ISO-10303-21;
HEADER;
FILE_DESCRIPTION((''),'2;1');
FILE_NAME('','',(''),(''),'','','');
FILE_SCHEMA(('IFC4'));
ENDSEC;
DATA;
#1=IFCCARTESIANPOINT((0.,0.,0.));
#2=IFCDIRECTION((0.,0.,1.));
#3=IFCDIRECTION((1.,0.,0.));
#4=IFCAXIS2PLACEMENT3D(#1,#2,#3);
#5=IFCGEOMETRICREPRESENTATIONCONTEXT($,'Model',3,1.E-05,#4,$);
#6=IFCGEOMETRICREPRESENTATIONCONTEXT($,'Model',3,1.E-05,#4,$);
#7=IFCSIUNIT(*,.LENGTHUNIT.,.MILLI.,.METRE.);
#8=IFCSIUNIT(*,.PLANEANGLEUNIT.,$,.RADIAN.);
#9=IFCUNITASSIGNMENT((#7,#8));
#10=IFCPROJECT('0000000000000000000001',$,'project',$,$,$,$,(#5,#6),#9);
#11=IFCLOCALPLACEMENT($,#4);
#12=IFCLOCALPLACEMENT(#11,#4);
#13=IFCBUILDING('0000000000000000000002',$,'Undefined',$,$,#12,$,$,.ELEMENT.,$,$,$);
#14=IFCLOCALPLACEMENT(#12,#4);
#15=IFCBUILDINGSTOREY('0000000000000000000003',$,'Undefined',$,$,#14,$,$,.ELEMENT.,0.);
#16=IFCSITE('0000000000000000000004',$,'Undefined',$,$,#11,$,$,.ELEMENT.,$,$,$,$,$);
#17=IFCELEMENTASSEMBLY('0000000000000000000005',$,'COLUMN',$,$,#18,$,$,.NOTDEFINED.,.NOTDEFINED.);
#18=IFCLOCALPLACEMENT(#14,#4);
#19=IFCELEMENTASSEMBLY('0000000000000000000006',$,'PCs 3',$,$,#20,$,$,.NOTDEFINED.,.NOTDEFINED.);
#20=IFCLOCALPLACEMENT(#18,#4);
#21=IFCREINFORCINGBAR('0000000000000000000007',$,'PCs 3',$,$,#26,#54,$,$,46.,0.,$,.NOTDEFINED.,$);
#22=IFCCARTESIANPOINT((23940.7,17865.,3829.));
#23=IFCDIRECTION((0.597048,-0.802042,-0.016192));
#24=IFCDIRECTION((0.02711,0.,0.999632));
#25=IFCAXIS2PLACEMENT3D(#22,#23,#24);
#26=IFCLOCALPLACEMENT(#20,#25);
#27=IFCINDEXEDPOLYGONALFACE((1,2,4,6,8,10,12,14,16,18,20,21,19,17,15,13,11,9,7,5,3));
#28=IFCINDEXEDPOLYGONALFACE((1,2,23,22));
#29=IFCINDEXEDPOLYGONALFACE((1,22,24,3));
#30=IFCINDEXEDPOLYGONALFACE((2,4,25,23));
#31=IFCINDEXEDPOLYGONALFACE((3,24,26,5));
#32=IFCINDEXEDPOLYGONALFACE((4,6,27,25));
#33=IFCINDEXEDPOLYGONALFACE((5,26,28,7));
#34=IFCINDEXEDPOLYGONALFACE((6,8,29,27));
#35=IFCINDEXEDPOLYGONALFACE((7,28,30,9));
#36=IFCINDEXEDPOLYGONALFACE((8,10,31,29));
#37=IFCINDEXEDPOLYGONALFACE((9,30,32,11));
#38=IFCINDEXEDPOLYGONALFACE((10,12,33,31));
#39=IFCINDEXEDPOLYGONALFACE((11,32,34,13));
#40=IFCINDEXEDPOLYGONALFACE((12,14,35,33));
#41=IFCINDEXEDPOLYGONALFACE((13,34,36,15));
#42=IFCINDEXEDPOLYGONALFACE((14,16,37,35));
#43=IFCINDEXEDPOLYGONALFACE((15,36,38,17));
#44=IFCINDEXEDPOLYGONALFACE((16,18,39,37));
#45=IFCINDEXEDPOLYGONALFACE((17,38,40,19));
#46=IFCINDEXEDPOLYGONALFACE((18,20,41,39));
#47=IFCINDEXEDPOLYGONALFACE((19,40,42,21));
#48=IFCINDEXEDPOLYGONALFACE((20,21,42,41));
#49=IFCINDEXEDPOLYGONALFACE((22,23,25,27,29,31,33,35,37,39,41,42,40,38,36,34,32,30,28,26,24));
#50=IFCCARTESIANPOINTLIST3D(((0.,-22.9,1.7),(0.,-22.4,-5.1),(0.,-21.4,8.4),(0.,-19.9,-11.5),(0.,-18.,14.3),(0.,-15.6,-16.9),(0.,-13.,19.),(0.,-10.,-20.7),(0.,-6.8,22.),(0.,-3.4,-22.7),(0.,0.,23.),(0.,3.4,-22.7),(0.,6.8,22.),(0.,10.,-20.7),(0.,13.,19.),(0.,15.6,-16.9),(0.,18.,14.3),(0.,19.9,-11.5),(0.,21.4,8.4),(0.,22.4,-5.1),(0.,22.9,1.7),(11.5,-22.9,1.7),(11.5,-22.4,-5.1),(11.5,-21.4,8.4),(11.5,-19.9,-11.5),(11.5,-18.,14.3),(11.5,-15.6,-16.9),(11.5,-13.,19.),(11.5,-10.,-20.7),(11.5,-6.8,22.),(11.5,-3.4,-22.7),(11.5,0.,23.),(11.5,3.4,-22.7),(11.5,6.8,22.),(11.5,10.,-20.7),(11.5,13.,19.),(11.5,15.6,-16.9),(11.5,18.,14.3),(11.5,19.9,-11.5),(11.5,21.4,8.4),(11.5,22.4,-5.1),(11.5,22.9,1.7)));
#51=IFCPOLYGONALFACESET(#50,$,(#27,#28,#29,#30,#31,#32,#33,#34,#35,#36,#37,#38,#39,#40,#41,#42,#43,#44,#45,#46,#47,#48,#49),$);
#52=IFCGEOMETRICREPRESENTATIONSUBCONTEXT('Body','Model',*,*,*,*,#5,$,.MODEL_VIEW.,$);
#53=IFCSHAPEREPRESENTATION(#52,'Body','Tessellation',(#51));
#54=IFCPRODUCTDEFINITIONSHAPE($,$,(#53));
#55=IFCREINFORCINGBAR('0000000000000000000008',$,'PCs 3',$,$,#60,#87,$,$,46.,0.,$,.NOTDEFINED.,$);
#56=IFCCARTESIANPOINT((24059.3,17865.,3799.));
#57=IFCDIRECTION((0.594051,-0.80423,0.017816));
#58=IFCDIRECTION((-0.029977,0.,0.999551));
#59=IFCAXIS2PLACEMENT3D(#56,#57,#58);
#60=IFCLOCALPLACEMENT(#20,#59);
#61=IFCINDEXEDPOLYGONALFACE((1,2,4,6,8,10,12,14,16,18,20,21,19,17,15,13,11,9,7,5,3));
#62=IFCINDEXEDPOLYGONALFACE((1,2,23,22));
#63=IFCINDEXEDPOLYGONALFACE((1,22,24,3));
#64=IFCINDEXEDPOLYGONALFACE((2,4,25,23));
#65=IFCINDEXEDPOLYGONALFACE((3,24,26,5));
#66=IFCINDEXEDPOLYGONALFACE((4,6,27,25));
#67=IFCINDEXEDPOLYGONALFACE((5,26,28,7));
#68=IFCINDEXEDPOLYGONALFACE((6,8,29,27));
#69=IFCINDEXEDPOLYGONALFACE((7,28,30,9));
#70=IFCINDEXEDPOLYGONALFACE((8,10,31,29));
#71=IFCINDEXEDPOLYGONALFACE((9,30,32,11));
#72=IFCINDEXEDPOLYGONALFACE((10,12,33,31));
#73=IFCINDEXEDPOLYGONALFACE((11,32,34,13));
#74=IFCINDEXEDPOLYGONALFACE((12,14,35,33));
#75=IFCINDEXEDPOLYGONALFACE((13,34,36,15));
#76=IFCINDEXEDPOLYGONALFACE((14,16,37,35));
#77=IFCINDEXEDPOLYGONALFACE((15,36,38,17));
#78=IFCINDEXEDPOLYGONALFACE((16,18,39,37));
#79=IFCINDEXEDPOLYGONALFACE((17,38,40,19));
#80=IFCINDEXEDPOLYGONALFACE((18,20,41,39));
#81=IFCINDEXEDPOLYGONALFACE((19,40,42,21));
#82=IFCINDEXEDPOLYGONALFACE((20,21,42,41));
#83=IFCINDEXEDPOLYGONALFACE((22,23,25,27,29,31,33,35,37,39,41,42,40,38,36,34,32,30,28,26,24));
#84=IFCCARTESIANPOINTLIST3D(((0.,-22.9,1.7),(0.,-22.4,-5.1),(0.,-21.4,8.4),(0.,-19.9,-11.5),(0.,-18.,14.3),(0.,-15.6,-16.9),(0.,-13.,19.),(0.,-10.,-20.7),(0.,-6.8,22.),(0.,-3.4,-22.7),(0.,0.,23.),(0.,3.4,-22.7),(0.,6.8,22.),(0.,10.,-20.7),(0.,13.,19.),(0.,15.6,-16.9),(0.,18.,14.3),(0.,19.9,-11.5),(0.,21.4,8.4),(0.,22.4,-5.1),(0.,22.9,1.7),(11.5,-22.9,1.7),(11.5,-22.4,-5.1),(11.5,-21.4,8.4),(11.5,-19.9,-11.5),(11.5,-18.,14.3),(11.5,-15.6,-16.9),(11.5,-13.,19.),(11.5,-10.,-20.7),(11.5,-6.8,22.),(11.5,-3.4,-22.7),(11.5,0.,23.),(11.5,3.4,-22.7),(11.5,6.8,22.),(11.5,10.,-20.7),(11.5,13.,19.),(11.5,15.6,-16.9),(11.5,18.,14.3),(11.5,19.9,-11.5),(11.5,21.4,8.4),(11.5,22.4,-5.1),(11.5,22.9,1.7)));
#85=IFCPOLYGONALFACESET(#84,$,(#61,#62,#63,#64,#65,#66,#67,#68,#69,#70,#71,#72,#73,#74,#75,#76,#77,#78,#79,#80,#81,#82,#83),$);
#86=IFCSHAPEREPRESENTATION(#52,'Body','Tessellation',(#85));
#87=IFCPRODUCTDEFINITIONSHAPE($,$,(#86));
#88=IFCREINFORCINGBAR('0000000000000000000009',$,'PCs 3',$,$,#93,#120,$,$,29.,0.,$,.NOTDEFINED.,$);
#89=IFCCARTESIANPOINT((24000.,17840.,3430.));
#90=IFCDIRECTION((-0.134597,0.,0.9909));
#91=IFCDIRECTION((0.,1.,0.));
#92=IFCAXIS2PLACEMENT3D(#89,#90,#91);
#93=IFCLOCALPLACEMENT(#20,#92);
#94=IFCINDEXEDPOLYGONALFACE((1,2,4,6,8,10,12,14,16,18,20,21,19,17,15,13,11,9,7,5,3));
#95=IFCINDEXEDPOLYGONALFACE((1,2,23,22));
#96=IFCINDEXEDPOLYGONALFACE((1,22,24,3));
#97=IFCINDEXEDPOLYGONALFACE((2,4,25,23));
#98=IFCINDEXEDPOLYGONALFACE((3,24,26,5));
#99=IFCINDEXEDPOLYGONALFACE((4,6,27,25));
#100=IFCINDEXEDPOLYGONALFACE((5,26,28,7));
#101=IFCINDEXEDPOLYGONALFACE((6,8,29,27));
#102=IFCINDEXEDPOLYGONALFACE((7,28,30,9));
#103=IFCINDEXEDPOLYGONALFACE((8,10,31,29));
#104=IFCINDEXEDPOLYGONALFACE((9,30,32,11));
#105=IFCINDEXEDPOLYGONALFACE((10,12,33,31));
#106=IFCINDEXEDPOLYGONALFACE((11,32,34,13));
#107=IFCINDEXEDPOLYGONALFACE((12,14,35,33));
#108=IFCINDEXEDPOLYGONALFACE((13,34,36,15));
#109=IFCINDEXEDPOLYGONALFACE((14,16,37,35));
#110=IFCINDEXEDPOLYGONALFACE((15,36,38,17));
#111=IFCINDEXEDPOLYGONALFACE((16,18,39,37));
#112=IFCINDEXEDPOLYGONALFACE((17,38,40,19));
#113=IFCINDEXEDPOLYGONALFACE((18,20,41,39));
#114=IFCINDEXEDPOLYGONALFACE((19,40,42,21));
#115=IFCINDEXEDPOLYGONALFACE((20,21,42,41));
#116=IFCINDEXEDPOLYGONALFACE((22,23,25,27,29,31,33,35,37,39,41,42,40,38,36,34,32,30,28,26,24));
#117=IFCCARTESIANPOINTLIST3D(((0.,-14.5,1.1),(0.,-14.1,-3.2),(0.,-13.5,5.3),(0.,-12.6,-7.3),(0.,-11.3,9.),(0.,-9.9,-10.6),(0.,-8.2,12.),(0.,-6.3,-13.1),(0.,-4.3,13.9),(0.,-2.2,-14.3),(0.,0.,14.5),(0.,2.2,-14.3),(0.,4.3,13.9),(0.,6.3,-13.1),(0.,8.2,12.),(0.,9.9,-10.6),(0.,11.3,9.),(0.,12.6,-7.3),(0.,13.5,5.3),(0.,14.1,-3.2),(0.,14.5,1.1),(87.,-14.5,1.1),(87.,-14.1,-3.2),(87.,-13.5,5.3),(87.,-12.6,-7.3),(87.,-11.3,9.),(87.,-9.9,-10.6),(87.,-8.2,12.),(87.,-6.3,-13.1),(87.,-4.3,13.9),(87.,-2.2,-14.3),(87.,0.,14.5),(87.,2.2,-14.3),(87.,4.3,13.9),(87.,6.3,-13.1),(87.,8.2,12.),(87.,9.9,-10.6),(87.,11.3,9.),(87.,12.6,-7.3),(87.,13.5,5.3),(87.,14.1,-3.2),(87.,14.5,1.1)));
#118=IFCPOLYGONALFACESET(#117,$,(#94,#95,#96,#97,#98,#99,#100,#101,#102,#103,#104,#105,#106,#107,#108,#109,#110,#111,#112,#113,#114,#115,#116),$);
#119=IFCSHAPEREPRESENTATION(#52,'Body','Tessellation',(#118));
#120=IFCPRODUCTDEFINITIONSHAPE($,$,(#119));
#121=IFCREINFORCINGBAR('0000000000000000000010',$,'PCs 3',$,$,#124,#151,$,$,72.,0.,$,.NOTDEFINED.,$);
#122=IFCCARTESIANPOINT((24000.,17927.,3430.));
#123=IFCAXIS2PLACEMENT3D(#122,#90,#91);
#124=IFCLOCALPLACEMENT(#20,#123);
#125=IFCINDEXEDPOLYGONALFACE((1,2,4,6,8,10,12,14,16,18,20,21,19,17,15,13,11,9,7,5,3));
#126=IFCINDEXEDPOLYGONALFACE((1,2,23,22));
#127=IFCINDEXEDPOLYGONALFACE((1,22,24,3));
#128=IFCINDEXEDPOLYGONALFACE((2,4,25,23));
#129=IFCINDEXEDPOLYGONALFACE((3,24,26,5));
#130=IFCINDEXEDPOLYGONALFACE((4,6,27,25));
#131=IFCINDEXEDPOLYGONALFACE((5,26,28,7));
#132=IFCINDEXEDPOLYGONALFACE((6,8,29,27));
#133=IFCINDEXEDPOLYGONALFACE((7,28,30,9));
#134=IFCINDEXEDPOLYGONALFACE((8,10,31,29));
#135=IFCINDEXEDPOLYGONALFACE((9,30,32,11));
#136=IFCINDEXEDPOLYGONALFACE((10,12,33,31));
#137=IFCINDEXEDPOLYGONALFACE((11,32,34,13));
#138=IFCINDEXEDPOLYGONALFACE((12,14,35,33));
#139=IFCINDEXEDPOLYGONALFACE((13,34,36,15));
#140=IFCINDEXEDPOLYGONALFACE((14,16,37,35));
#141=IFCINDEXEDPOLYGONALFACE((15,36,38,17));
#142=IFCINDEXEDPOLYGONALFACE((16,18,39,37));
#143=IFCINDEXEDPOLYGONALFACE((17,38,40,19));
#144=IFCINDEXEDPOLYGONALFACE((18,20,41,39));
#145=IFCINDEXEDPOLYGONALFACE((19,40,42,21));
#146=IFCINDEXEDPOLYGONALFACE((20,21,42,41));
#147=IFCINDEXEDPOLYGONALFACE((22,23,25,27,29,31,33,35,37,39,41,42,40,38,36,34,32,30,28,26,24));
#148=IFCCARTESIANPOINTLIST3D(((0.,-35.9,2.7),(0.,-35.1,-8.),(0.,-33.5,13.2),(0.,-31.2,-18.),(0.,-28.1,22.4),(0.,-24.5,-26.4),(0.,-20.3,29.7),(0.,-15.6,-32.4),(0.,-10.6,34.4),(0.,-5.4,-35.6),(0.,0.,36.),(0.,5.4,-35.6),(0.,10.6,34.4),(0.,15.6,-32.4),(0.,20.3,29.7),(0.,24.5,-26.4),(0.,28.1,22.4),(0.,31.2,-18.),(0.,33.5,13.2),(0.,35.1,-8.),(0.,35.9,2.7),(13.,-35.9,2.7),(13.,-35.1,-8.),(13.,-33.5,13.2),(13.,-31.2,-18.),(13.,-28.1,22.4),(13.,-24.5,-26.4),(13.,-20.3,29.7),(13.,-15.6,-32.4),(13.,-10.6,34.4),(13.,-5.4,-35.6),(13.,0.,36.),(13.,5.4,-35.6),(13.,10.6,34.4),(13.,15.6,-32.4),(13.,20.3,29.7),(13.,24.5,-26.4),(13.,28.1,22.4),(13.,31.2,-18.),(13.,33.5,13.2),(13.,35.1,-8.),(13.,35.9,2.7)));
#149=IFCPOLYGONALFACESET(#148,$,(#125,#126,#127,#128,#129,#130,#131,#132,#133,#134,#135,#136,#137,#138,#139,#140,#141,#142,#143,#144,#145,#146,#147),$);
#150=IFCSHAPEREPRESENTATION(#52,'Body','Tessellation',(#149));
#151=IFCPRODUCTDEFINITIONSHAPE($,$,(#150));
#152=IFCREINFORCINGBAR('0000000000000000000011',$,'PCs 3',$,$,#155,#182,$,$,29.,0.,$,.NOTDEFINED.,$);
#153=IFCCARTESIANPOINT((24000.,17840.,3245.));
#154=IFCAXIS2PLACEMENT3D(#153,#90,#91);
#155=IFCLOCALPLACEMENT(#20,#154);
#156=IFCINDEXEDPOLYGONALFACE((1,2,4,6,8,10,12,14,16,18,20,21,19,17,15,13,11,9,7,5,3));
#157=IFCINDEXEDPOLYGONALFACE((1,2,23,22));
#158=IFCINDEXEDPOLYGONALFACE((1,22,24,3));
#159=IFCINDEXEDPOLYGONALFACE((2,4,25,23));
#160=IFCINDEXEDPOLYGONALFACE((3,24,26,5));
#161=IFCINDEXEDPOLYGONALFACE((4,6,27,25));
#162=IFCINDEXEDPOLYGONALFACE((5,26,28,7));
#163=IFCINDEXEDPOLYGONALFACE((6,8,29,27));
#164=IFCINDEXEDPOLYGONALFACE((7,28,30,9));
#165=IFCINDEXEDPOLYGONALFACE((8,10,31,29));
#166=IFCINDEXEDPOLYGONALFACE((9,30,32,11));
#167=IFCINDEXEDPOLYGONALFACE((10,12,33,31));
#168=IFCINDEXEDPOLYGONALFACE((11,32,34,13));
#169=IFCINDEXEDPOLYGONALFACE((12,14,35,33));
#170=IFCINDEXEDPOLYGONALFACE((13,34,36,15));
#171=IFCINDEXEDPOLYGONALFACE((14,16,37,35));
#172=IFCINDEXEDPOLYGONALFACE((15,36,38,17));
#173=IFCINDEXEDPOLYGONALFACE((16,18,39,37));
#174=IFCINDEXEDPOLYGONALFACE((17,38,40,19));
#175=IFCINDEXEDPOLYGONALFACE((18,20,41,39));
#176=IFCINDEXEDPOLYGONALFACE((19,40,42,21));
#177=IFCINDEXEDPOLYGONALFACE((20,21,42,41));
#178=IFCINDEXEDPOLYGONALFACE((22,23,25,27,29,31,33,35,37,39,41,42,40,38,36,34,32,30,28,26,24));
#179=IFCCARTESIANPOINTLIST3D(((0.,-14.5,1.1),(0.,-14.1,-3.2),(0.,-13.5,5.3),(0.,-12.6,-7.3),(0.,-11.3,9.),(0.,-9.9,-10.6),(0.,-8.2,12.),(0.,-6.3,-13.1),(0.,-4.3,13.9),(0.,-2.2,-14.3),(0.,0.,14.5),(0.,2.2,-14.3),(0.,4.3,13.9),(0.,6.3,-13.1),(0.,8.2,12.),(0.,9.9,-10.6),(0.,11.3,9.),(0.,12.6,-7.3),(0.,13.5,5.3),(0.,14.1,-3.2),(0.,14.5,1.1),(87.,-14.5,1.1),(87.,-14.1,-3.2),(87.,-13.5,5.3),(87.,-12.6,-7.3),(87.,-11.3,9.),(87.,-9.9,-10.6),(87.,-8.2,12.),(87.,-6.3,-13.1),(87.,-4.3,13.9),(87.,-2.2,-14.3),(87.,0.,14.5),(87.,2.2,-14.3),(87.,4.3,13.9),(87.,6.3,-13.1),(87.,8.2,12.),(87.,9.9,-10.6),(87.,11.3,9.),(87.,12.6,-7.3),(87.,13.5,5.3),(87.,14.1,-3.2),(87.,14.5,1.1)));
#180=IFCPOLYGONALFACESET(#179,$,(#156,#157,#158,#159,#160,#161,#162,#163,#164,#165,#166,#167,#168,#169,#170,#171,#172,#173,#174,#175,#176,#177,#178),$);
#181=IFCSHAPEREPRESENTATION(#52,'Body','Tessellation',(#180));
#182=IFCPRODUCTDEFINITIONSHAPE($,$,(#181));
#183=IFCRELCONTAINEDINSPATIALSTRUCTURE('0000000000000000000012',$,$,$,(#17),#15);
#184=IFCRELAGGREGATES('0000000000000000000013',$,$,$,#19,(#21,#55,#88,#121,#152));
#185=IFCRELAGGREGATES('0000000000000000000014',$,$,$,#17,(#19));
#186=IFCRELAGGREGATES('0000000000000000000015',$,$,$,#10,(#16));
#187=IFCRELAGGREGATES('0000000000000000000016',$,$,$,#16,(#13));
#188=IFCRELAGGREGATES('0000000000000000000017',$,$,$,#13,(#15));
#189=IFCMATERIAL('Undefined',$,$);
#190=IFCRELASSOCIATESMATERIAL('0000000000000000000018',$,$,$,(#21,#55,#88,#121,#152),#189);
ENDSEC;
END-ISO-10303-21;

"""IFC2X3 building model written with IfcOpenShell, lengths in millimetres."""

from ifc_helpers import new_model, entity, si_unit, frame, origin_with_axes, place, context, subcontext, project, spatial, source, transform, mapped, material, element, aggregate, save


model = new_model("IFC2X3")

# Units and contexts
model_context_1 = context("Model", 3, precision=1e-05, world=origin_with_axes())
model_context_2 = context("Model", 3, precision=1e-05, world=origin_with_axes())
body_context = subcontext(model_context_1, "Body", "Model", "MODEL_VIEW")
ifc_project = project(units=[si_unit("LENGTHUNIT", "METRE", prefix="MILLI"), si_unit("PLANEANGLEUNIT", "RADIAN")], contexts=[model_context_1, model_context_2])

# Site, building, storey
site_placement = place(None, origin_with_axes())
site = spatial("IfcSite", under=ifc_project, at=site_placement, Name="Undefined", CompositionType="ELEMENT")
building_placement = place(site_placement, origin_with_axes())
building = spatial("IfcBuilding", under=site, at=building_placement, Name="Undefined", CompositionType="ELEMENT")
storey_placement = place(building_placement, origin_with_axes())
storey = spatial("IfcBuildingStorey", under=building, at=storey_placement, Name="Undefined", CompositionType="ELEMENT", Elevation=0.0)

# Element assemblies
assembly_1_placement = place(storey_placement, origin_with_axes())
assembly_1 = element("IfcElementAssembly", 1, at=assembly_1_placement, inside=storey, Name="COLUMN", AssemblyPlace="NOTDEFINED", PredefinedType="NOTDEFINED")
assembly_2_placement = place(assembly_1_placement, origin_with_axes())
assembly_2 = element("IfcElementAssembly", 2, at=assembly_2_placement, Name="PCs 3", AssemblyPlace="NOTDEFINED", PredefinedType="NOTDEFINED")

# Reinforcing bars
ifc_material_1 = material(Name="Undefined")
shared_shape_1 = source(origin_with_axes(), body_context, "Body", "AdvancedSweptSolid", [
    entity("IfcSweptDiskSolid", entity("IfcTrimmedCurve", entity("IfcLine", entity("IfcCartesianPoint", [0.0, 0.0, 0.0]), entity("IfcVector", entity("IfcDirection", [1.0, 0.0, 0.0]), 1.0)), [entity("IfcParameterValue", 0.0)], [entity("IfcParameterValue", 11.5)], True, "PARAMETER"), 23.0, None, 0.0, 11.5),
])
reinforcing_bar_1_placement = place(assembly_2_placement, frame((23940.7, 17865.0, 3829.0), z_axis=(0.597048, -0.802042, -0.016192), x_axis=(0.02711, 0.0, 0.999632)))
reinforcing_bar_1 = element("IfcReinforcingBar", 3, at=reinforcing_bar_1_placement, material=ifc_material_1, Name="PCs 3", BarRole="NOTDEFINED", CrossSectionArea=0.0, NominalDiameter=46.0, context=body_context, shape_type="MappedRepresentation", body=[
    mapped(shared_shape_1, transform((0.0, 0.0, 0.0))),
])
shared_shape_2 = source(origin_with_axes(), body_context, "Body", "AdvancedSweptSolid", [
    entity("IfcSweptDiskSolid", entity("IfcTrimmedCurve", entity("IfcLine", entity("IfcCartesianPoint", [0.0, 0.0, 0.0]), entity("IfcVector", entity("IfcDirection", [1.0, 0.0, 0.0]), 1.0)), [entity("IfcParameterValue", 0.0)], [entity("IfcParameterValue", 11.5)], True, "PARAMETER"), 23.0, None, 0.0, 11.5),
])
reinforcing_bar_2_placement = place(assembly_2_placement, frame((24059.3, 17865.0, 3799.0), z_axis=(0.594051, -0.80423, 0.017816), x_axis=(-0.029977, 0.0, 0.999551)))
reinforcing_bar_2 = element("IfcReinforcingBar", 4, at=reinforcing_bar_2_placement, material=ifc_material_1, Name="PCs 3", BarRole="NOTDEFINED", CrossSectionArea=0.0, NominalDiameter=46.0, context=body_context, shape_type="MappedRepresentation", body=[
    mapped(shared_shape_2, transform((0.0, 0.0, 0.0))),
])
shared_shape_3 = source(origin_with_axes(), body_context, "Body", "AdvancedSweptSolid", [
    entity("IfcSweptDiskSolid", entity("IfcTrimmedCurve", entity("IfcLine", entity("IfcCartesianPoint", [0.0, 0.0, 0.0]), entity("IfcVector", entity("IfcDirection", [1.0, 0.0, 0.0]), 1.0)), [entity("IfcParameterValue", 0.0)], [entity("IfcParameterValue", 87.0)], True, "PARAMETER"), 14.5, None, 0.0, 87.0),
])
reinforcing_bar_3_placement = place(assembly_2_placement, frame((24000.0, 17840.0, 3430.0), z_axis=(-0.134597, 0.0, 0.9909), x_axis=(0.0, 1.0, 0.0)))
reinforcing_bar_3 = element("IfcReinforcingBar", 5, at=reinforcing_bar_3_placement, material=ifc_material_1, Name="PCs 3", BarRole="NOTDEFINED", CrossSectionArea=0.0, NominalDiameter=29.0, context=body_context, shape_type="MappedRepresentation", body=[
    mapped(shared_shape_3, transform((0.0, 0.0, 0.0))),
])
shared_shape_4 = source(origin_with_axes(), body_context, "Body", "AdvancedSweptSolid", [
    entity("IfcSweptDiskSolid", entity("IfcTrimmedCurve", entity("IfcLine", entity("IfcCartesianPoint", [0.0, 0.0, 0.0]), entity("IfcVector", entity("IfcDirection", [1.0, 0.0, 0.0]), 1.0)), [entity("IfcParameterValue", 0.0)], [entity("IfcParameterValue", 13.0)], True, "PARAMETER"), 36.0, None, 0.0, 13.0),
])
reinforcing_bar_4_placement = place(assembly_2_placement, frame((24000.0, 17927.0, 3430.0), z_axis=(-0.134597, 0.0, 0.9909), x_axis=(0.0, 1.0, 0.0)))
reinforcing_bar_4 = element("IfcReinforcingBar", 6, at=reinforcing_bar_4_placement, material=ifc_material_1, Name="PCs 3", BarRole="NOTDEFINED", CrossSectionArea=0.0, NominalDiameter=72.0, context=body_context, shape_type="MappedRepresentation", body=[
    mapped(shared_shape_4, transform((0.0, 0.0, 0.0))),
])
shared_shape_5 = source(origin_with_axes(), body_context, "Body", "AdvancedSweptSolid", [
    entity("IfcSweptDiskSolid", entity("IfcTrimmedCurve", entity("IfcLine", entity("IfcCartesianPoint", [0.0, 0.0, 0.0]), entity("IfcVector", entity("IfcDirection", [1.0, 0.0, 0.0]), 1.0)), [entity("IfcParameterValue", 0.0)], [entity("IfcParameterValue", 87.0)], True, "PARAMETER"), 14.5, None, 0.0, 87.0),
])
reinforcing_bar_5_placement = place(assembly_2_placement, frame((24000.0, 17840.0, 3245.0), z_axis=(-0.134597, 0.0, 0.9909), x_axis=(0.0, 1.0, 0.0)))
reinforcing_bar_5 = element("IfcReinforcingBar", 7, at=reinforcing_bar_5_placement, material=ifc_material_1, Name="PCs 3", BarRole="NOTDEFINED", CrossSectionArea=0.0, NominalDiameter=29.0, context=body_context, shape_type="MappedRepresentation", body=[
    mapped(shared_shape_5, transform((0.0, 0.0, 0.0))),
])
aggregate(assembly_2, [reinforcing_bar_1, reinforcing_bar_2, reinforcing_bar_3, reinforcing_bar_4, reinforcing_bar_5])
aggregate(assembly_1, [assembly_2])

save(model, "model.ifc")
